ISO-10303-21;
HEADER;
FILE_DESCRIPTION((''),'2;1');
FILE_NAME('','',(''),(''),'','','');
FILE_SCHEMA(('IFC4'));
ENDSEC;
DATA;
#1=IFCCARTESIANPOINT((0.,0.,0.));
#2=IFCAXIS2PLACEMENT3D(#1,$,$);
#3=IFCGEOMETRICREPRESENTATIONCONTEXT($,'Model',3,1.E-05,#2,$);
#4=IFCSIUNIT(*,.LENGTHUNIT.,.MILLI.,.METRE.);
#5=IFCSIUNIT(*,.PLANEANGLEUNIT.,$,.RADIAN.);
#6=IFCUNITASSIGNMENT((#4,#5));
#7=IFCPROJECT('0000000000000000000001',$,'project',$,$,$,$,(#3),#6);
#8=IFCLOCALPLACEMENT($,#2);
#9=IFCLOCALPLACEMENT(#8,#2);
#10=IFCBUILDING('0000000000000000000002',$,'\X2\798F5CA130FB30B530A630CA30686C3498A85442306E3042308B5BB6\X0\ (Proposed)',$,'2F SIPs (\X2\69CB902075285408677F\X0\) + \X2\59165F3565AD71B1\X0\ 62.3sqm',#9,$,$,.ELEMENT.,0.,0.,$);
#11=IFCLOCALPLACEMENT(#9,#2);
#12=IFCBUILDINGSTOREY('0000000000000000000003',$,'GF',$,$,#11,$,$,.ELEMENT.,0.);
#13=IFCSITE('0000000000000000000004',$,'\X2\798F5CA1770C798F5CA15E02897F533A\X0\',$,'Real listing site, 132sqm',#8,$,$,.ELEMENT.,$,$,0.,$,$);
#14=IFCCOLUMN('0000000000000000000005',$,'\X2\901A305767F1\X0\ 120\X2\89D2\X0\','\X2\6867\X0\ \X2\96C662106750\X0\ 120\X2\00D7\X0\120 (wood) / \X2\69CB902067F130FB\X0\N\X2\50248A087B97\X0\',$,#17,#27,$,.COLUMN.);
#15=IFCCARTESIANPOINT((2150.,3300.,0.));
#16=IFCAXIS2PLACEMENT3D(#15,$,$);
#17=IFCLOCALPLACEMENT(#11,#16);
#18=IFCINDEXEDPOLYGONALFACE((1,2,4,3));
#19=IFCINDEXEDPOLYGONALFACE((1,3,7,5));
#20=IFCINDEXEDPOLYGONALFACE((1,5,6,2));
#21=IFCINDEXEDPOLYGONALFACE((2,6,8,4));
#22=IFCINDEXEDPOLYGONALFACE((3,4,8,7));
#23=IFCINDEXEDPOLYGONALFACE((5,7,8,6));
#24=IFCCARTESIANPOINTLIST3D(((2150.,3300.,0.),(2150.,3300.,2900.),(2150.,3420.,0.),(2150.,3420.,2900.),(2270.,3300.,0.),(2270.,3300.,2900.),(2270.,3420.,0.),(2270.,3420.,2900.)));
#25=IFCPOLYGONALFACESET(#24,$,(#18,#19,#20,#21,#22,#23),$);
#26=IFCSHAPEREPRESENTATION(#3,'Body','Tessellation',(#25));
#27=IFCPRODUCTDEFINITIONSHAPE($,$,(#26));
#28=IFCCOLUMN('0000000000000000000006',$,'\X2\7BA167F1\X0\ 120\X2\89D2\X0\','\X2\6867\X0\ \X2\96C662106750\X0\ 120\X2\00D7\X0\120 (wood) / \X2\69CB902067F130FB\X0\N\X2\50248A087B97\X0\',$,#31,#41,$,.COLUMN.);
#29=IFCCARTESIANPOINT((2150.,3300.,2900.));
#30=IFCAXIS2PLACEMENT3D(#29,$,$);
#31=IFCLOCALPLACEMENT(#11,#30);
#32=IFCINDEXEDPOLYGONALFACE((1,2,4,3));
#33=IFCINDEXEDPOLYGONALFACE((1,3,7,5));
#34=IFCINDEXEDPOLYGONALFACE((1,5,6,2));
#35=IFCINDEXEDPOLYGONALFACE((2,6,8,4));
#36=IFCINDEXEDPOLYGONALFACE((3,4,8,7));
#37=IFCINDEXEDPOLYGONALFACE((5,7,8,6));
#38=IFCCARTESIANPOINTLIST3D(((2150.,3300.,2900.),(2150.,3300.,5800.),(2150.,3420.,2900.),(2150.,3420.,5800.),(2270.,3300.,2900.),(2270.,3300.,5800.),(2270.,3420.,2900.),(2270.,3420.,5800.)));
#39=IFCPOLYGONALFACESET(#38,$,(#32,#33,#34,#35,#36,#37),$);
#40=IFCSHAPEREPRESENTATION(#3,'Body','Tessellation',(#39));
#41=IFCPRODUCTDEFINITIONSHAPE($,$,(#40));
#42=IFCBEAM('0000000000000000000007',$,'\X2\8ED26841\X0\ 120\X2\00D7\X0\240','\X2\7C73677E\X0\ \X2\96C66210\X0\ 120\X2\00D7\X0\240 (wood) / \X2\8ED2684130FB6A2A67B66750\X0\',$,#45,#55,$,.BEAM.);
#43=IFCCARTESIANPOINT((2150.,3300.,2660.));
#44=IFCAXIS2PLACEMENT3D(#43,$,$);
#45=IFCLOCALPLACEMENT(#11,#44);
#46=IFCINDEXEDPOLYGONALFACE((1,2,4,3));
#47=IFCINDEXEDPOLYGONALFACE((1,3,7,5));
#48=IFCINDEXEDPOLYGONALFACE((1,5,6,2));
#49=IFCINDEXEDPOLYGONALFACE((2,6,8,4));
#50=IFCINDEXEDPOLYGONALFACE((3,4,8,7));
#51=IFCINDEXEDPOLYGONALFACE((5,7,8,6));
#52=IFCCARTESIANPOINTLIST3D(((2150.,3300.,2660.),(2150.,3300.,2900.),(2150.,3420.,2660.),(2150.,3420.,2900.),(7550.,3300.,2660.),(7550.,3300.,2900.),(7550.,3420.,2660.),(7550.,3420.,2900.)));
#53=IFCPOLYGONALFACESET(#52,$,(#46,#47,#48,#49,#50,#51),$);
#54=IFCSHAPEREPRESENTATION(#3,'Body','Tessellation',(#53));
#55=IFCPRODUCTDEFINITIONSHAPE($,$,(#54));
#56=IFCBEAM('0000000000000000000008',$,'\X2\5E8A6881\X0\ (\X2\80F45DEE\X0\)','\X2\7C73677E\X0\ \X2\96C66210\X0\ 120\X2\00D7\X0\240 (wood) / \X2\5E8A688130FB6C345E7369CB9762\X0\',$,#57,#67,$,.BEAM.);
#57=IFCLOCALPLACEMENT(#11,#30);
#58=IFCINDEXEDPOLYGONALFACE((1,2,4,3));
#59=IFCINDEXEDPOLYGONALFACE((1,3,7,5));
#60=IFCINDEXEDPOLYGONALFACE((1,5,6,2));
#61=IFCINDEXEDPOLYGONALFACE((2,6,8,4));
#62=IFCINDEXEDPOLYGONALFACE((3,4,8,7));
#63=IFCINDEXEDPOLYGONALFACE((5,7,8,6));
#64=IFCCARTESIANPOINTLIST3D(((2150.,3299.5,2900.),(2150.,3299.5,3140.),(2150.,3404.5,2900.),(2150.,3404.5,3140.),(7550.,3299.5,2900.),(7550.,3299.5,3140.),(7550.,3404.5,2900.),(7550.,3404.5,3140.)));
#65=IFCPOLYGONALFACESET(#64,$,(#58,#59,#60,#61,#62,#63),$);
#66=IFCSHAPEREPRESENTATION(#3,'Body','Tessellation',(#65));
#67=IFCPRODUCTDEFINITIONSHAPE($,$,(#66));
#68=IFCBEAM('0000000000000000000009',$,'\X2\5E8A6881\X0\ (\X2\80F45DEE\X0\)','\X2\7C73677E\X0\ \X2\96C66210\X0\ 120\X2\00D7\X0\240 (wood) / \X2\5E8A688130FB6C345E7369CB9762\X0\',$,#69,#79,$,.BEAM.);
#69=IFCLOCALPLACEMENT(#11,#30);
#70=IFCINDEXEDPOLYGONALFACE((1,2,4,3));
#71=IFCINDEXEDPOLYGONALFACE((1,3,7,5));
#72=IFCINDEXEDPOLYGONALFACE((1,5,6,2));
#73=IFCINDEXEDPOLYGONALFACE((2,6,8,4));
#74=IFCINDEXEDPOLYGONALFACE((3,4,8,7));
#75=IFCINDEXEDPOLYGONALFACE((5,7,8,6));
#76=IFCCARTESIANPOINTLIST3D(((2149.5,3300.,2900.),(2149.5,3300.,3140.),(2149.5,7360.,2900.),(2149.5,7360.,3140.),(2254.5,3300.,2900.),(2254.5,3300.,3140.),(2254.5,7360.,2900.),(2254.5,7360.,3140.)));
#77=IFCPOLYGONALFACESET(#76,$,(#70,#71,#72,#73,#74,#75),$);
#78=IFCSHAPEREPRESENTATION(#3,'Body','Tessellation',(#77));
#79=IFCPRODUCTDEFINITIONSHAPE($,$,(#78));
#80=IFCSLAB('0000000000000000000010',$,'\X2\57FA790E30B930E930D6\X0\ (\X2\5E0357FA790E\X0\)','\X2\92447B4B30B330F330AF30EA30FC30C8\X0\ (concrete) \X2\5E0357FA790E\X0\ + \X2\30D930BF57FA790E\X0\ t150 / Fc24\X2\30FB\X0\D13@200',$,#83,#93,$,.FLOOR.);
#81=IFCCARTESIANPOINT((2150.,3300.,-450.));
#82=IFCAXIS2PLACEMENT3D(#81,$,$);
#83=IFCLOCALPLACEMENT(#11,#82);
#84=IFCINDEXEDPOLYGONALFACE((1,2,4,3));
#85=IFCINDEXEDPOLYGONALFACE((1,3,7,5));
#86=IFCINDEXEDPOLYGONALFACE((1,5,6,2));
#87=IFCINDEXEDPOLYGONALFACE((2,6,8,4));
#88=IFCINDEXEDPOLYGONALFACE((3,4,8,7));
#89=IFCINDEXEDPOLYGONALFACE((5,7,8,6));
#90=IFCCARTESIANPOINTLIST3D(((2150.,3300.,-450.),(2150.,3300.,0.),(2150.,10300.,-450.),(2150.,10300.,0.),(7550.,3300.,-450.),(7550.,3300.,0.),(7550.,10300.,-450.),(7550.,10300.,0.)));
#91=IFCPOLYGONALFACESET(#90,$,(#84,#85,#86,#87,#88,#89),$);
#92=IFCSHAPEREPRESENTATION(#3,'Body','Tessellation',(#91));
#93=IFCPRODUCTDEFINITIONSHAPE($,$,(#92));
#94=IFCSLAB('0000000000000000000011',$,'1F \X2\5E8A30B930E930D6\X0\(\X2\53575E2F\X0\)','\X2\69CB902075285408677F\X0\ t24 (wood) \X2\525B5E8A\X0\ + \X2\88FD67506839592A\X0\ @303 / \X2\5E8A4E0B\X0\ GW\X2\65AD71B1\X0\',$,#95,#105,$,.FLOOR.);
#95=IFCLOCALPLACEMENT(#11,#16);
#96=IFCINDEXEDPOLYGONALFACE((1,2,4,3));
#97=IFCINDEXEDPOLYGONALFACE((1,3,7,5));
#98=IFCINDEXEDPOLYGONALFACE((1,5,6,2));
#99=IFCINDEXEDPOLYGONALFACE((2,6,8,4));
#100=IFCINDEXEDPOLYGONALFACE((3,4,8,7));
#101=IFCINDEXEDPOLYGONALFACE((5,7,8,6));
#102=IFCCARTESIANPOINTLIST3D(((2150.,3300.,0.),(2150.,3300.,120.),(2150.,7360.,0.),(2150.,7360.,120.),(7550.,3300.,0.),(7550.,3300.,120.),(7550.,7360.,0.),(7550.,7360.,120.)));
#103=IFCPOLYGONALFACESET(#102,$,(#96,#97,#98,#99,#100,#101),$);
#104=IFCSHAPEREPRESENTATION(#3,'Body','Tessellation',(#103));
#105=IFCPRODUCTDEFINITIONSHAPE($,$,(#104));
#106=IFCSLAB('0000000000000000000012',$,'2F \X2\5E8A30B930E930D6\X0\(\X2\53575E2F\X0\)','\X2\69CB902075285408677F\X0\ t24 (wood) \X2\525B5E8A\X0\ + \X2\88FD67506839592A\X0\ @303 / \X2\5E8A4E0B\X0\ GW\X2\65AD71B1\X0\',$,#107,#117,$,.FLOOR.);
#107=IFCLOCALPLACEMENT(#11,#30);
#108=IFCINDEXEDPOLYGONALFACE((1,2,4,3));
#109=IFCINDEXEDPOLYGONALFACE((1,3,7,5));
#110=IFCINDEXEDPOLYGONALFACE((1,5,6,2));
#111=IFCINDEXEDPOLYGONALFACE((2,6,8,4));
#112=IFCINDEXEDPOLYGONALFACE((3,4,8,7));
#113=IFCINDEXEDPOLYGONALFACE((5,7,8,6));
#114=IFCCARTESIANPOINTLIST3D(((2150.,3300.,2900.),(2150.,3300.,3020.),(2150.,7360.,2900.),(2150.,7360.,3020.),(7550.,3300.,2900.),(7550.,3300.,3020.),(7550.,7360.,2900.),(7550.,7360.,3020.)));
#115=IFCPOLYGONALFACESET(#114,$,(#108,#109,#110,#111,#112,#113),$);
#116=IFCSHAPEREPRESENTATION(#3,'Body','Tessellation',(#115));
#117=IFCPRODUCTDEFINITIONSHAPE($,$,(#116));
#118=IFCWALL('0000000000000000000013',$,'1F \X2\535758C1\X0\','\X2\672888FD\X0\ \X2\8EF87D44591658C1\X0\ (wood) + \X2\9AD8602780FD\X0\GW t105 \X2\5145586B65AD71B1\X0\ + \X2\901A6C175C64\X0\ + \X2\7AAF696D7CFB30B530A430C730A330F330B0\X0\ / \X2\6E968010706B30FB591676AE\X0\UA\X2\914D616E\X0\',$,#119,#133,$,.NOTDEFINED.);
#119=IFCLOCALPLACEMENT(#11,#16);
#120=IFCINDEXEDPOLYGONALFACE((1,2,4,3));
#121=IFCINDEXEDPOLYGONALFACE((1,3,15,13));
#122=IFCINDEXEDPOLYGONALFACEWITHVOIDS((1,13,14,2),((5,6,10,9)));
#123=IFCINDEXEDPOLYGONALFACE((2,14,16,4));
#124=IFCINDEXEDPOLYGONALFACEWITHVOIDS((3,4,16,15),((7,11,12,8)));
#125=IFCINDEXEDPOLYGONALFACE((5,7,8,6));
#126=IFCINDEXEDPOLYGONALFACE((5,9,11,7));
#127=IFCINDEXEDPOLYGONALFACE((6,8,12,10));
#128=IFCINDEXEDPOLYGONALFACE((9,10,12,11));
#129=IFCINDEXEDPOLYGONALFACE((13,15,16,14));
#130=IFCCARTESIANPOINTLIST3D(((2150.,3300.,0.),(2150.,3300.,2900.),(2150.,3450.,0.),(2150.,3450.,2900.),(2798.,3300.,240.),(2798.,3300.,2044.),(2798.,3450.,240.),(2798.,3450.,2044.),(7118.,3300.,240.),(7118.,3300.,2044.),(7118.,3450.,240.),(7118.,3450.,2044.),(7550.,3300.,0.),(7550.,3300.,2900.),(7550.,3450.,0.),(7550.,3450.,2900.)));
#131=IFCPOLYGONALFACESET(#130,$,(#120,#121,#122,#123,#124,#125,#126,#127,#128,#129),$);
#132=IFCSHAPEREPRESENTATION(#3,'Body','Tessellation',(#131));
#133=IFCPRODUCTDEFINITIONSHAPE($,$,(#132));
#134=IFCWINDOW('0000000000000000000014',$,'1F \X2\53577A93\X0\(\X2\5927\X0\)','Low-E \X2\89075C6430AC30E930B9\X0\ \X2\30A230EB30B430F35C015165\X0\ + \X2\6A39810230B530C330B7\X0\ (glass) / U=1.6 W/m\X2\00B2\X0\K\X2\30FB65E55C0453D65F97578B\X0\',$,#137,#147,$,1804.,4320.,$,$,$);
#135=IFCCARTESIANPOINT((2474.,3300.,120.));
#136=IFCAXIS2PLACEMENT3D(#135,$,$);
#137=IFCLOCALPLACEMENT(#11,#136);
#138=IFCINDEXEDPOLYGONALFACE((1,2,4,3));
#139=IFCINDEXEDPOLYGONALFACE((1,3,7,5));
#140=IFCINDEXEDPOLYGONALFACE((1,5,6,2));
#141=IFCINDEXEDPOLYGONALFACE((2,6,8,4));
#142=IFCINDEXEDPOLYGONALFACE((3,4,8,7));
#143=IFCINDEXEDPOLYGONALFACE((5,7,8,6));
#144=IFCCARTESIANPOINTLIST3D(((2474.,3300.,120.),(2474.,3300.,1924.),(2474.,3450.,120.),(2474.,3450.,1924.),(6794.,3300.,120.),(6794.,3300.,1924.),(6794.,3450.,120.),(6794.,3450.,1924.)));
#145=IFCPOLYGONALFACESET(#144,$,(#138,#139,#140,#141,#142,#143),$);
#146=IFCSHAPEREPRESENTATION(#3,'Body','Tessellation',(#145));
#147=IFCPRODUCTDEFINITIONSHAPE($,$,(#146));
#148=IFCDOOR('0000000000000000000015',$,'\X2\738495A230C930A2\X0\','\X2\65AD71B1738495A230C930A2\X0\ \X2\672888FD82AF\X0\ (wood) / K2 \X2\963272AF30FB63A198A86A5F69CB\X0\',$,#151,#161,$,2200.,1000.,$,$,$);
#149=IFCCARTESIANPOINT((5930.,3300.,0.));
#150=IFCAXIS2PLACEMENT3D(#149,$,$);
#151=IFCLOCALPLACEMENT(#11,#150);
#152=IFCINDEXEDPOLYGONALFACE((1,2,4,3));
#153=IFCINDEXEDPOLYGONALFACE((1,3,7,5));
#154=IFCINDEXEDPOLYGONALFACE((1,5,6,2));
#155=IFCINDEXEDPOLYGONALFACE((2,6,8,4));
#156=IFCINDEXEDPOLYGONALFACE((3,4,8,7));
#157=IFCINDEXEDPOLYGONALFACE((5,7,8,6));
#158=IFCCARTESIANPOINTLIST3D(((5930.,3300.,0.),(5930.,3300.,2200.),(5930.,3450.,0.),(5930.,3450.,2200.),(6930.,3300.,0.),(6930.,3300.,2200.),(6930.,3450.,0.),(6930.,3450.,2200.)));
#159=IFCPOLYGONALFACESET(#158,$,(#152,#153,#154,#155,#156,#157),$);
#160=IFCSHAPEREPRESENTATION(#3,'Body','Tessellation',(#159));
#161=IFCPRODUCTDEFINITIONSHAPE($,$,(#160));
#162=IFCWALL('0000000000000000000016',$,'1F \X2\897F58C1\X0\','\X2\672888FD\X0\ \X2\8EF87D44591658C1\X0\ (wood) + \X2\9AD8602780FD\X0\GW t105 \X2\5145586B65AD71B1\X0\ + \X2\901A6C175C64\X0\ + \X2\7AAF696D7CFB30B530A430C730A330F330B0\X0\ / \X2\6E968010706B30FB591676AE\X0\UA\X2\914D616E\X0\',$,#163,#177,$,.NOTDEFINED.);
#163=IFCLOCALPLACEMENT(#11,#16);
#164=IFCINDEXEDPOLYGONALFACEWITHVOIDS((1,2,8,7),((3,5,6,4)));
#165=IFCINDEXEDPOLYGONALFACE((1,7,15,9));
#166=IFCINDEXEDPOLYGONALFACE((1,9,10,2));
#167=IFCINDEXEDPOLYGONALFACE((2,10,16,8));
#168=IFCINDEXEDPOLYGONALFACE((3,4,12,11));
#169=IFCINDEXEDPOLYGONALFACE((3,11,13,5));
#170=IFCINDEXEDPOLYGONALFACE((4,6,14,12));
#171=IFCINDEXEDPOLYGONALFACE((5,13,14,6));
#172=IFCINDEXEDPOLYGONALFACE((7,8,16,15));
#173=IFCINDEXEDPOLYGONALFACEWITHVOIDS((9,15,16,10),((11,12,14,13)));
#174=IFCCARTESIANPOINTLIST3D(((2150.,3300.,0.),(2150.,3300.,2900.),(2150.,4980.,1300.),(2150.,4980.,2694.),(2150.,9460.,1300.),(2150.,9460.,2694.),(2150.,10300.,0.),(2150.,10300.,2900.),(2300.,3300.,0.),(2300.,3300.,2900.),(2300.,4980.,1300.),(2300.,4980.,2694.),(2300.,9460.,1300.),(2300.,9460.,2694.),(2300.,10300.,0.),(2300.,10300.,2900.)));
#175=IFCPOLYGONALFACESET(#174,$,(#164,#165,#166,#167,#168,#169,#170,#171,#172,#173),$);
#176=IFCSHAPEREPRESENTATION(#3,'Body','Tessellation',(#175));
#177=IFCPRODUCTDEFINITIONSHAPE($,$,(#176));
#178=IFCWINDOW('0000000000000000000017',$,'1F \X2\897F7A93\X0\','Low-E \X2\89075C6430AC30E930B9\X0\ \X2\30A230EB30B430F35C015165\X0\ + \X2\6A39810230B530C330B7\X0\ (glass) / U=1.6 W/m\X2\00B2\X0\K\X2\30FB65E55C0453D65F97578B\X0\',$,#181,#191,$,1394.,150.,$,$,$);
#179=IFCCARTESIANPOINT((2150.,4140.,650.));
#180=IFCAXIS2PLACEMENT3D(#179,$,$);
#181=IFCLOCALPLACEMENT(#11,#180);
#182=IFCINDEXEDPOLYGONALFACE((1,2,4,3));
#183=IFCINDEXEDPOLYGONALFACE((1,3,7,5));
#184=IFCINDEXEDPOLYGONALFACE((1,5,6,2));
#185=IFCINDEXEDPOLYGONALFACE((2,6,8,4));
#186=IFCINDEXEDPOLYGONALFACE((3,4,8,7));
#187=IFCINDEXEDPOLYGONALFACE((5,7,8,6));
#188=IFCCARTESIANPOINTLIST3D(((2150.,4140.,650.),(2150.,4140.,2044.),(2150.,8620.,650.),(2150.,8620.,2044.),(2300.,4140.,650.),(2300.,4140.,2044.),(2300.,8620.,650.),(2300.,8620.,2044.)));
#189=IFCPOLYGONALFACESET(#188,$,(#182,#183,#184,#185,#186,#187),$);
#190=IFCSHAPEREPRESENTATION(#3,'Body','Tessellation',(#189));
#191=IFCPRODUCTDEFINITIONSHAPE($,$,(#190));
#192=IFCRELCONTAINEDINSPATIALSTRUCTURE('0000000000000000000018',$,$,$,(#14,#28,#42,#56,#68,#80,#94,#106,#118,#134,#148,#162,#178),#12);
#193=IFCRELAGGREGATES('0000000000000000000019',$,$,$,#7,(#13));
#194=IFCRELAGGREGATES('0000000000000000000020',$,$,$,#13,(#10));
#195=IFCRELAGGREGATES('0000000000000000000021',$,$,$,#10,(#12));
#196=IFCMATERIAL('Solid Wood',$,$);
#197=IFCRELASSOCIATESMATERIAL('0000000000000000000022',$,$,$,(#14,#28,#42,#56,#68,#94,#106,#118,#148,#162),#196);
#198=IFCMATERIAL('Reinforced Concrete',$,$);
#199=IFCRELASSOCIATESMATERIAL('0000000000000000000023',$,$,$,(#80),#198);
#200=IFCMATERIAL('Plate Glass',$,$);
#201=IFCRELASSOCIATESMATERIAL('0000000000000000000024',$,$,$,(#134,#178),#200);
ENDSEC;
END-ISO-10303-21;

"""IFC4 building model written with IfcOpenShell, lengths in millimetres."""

from ifc_helpers import new_model, si_unit, frame, frame_2d, origin, place, context, project, spatial, rectangle, extrude, material, element, fill, save


model = new_model("IFC4")

# Units and contexts
model_context = context("Model", 3, precision=1e-05, world=origin())
ifc_project = project(units=[si_unit("LENGTHUNIT", "METRE", prefix="MILLI"), si_unit("PLANEANGLEUNIT", "RADIAN")], contexts=[model_context])

# Site, building, storey
site_placement = place(None, origin())
site = spatial("IfcSite", under=ifc_project, at=site_placement, Name="福岡県福岡市西区", ObjectType="Real listing site, 132sqm", CompositionType="ELEMENT", RefElevation=0.0)
building_placement = place(site_placement, origin())
building = spatial("IfcBuilding", under=site, at=building_placement, Name="福岡・サウナと水風呂のある家 (Proposed)", ObjectType="2F SIPs (構造用合板) + 外張断熱 62.3sqm", CompositionType="ELEMENT", ElevationOfRefHeight=0.0, ElevationOfTerrain=0.0)
storey_placement = place(building_placement, origin())
storey = spatial("IfcBuildingStorey", under=building, at=storey_placement, Name="GF", CompositionType="ELEMENT", Elevation=0.0)

# Columns
ifc_material_1 = material(Name="Solid Wood")
column_1_placement = place(storey_placement, frame((2150.0, 3300.0, 0.0)))
element("IfcColumn", 1, at=column_1_placement, inside=storey, material=ifc_material_1, Name="通し柱 120角", Description="桧 集成材 120×120 (wood) / 構造柱・N値計算", PredefinedType="COLUMN", context=model_context, shape_type="SweptSolid", body=[
    extrude(rectangle(XDim=120.0, YDim=120.0, at=frame_2d((60.0, 60.0))), frame((2150.0, 3300.0, 0.0)), (0.0, 0.0, 1.0), 2900.0),
])
column_2_placement = place(storey_placement, frame((2150.0, 3300.0, 2900.0)))
element("IfcColumn", 2, at=column_2_placement, inside=storey, material=ifc_material_1, Name="管柱 120角", Description="桧 集成材 120×120 (wood) / 構造柱・N値計算", PredefinedType="COLUMN", context=model_context, shape_type="SweptSolid", body=[
    extrude(rectangle(XDim=120.0, YDim=120.0, at=frame_2d((60.0, 60.0))), frame((2150.0, 3300.0, 2900.0)), (0.0, 0.0, 1.0), 2900.0),
])

# Beams
beam_1_placement = place(storey_placement, frame((2150.0, 3300.0, 2660.0)))
element("IfcBeam", 3, at=beam_1_placement, inside=storey, material=ifc_material_1, Name="軒桁 120×240", Description="米松 集成 120×240 (wood) / 軒桁・横架材", PredefinedType="BEAM", context=model_context, shape_type="SweptSolid", body=[
    extrude(rectangle(XDim=5400.0, YDim=120.0, at=frame_2d((2700.0, 60.0))), frame((2150.0, 3300.0, 2660.0)), (0.0, 0.0, 1.0), 240.0),
])
beam_2_placement = place(storey_placement, frame((2150.0, 3300.0, 2900.0)))
element("IfcBeam", 4, at=beam_2_placement, inside=storey, material=ifc_material_1, Name="床梁 (胴差)", Description="米松 集成 120×240 (wood) / 床梁・水平構面", PredefinedType="BEAM", context=model_context, shape_type="SweptSolid", body=[
    extrude(rectangle(XDim=5400.0, YDim=105.0, at=frame_2d((2700.0, 52.0))), frame((2150.0, 3300.0, 2900.0)), (0.0, 0.0, 1.0), 240.0),
])
beam_3_placement = place(storey_placement, frame((2150.0, 3300.0, 2900.0)))
element("IfcBeam", 5, at=beam_3_placement, inside=storey, material=ifc_material_1, Name="床梁 (胴差)", Description="米松 集成 120×240 (wood) / 床梁・水平構面", PredefinedType="BEAM", context=model_context, shape_type="SweptSolid", body=[
    extrude(rectangle(XDim=105.0, YDim=4060.0, at=frame_2d((52.0, 2030.0))), frame((2150.0, 3300.0, 2900.0)), (0.0, 0.0, 1.0), 240.0),
])

# Slabs
ifc_material_2 = material(Name="Reinforced Concrete")
slab_1_placement = place(storey_placement, frame((2150.0, 3300.0, -450.0)))
element("IfcSlab", 6, at=slab_1_placement, inside=storey, material=ifc_material_2, Name="基礎スラブ (布基礎)", Description="鉄筋コンクリート (concrete) 布基礎 + ベタ基礎 t150 / Fc24・D13@200", PredefinedType="FLOOR", context=model_context, shape_type="SweptSolid", body=[
    extrude(rectangle(XDim=5400.0, YDim=7000.0, at=frame_2d((2700.0, 3500.0))), frame((2150.0, 3300.0, -450.0)), (0.0, 0.0, 1.0), 450.0),
])
slab_2_placement = place(storey_placement, frame((2150.0, 3300.0, 0.0)))
element("IfcSlab", 7, at=slab_2_placement, inside=storey, material=ifc_material_1, Name="1F 床スラブ(南帯)", Description="構造用合板 t24 (wood) 剛床 + 製材根太 @303 / 床下 GW断熱", PredefinedType="FLOOR", context=model_context, shape_type="SweptSolid", body=[
    extrude(rectangle(XDim=5400.0, YDim=4060.0, at=frame_2d((2700.0, 2030.0))), frame((2150.0, 3300.0, 0.0)), (0.0, 0.0, 1.0), 120.0),
])
slab_3_placement = place(storey_placement, frame((2150.0, 3300.0, 2900.0)))
element("IfcSlab", 8, at=slab_3_placement, inside=storey, material=ifc_material_1, Name="2F 床スラブ(南帯)", Description="構造用合板 t24 (wood) 剛床 + 製材根太 @303 / 床下 GW断熱", PredefinedType="FLOOR", context=model_context, shape_type="SweptSolid", body=[
    extrude(rectangle(XDim=5400.0, YDim=4060.0, at=frame_2d((2700.0, 2030.0))), frame((2150.0, 3300.0, 2900.0)), (0.0, 0.0, 1.0), 120.0),
])

# Wall, openings, window, door
wall_1_placement = place(storey_placement, frame((2150.0, 3300.0, 0.0)))
wall_1 = element("IfcWall", 9, at=wall_1_placement, inside=storey, material=ifc_material_1, Name="1F 南壁", Description="木製 軸組外壁 (wood) + 高性能GW t105 充填断熱 + 通気層 + 窯業系サイディング / 準耐火・外皮UA配慮", PredefinedType="NOTDEFINED", context=model_context, shape_type="SweptSolid", body=[
    extrude(rectangle(XDim=5400.0, YDim=150.0, at=frame_2d((2700.0, 75.0))), frame((2150.0, 3300.0, 0.0)), (0.0, 0.0, 1.0), 2900.0),
])
opening_1_placement = place(storey_placement, frame((2474.0, 3300.0, 120.0)))
opening_1 = element("IfcOpeningElement", 10, at=opening_1_placement, cuts=wall_1, PredefinedType="NOTDEFINED", context=model_context, shape_type="SweptSolid", body=[
    extrude(rectangle(XDim=4320.0, YDim=150.0, at=frame_2d((2160.0, 75.0))), frame((2474.0, 3300.0, 120.0)), (0.0, 0.0, 1.0), 1804.0),
])
opening_2_placement = place(storey_placement, frame((5930.0, 3300.0, 0.0)))
opening_2 = element("IfcOpeningElement", 11, at=opening_2_placement, cuts=wall_1, PredefinedType="NOTDEFINED", context=model_context, shape_type="SweptSolid", body=[
    extrude(rectangle(XDim=1000.0, YDim=150.0, at=frame_2d((500.0, 75.0))), frame((5930.0, 3300.0, 0.0)), (0.0, 0.0, 1.0), 2200.0),
])
ifc_material_3 = material(Name="Plate Glass")
window_1_placement = place(storey_placement, frame((2474.0, 3300.0, 120.0)))
window_1 = element("IfcWindow", 12, at=window_1_placement, inside=storey, material=ifc_material_3, Name="1F 南窓(大)", Description="Low-E 複層ガラス アルゴン封入 + 樹脂サッシ (glass) / U=1.6 W/m²K・日射取得型", OverallHeight=1804.0, OverallWidth=4320.0, context=model_context, shape_type="SweptSolid", body=[
    extrude(rectangle(XDim=4320.0, YDim=150.0, at=frame_2d((2160.0, 75.0))), frame((2474.0, 3300.0, 120.0)), (0.0, 0.0, 1.0), 1804.0),
])
fill(opening_1, window_1)
door_placement = place(storey_placement, frame((5930.0, 3300.0, 0.0)))
door = element("IfcDoor", 13, at=door_placement, inside=storey, material=ifc_material_1, Name="玄関ドア", Description="断熱玄関ドア 木製芯 (wood) / K2 防犯・採風機構", OverallHeight=2200.0, OverallWidth=1000.0, context=model_context, shape_type="SweptSolid", body=[
    extrude(rectangle(XDim=1000.0, YDim=150.0, at=frame_2d((500.0, 75.0))), frame((5930.0, 3300.0, 0.0)), (0.0, 0.0, 1.0), 2200.0),
])
fill(opening_2, door)

# Wall, opening, window
wall_2_placement = place(storey_placement, frame((2150.0, 3300.0, 0.0)))
wall_2 = element("IfcWall", 14, at=wall_2_placement, inside=storey, material=ifc_material_1, Name="1F 西壁", Description="木製 軸組外壁 (wood) + 高性能GW t105 充填断熱 + 通気層 + 窯業系サイディング / 準耐火・外皮UA配慮", PredefinedType="NOTDEFINED", context=model_context, shape_type="SweptSolid", body=[
    extrude(rectangle(XDim=150.0, YDim=7000.0, at=frame_2d((75.0, 3500.0))), frame((2150.0, 3300.0, 0.0)), (0.0, 0.0, 1.0), 2900.0),
])
opening_3_placement = place(storey_placement, frame((2150.0, 4140.0, 650.0)))
opening_3 = element("IfcOpeningElement", 15, at=opening_3_placement, cuts=wall_2, PredefinedType="NOTDEFINED", context=model_context, shape_type="SweptSolid", body=[
    extrude(rectangle(XDim=150.0, YDim=4480.0, at=frame_2d((75.0, 2240.0))), frame((2150.0, 4140.0, 650.0)), (0.0, 0.0, 1.0), 1394.0),
])
window_2_placement = place(storey_placement, frame((2150.0, 4140.0, 650.0)))
window_2 = element("IfcWindow", 16, at=window_2_placement, inside=storey, material=ifc_material_3, Name="1F 西窓", Description="Low-E 複層ガラス アルゴン封入 + 樹脂サッシ (glass) / U=1.6 W/m²K・日射取得型", OverallHeight=1394.0, OverallWidth=150.0, context=model_context, shape_type="SweptSolid", body=[
    extrude(rectangle(XDim=150.0, YDim=4480.0, at=frame_2d((75.0, 2240.0))), frame((2150.0, 4140.0, 650.0)), (0.0, 0.0, 1.0), 1394.0),
])
fill(opening_3, window_2)

save(model, "model.ifc")
